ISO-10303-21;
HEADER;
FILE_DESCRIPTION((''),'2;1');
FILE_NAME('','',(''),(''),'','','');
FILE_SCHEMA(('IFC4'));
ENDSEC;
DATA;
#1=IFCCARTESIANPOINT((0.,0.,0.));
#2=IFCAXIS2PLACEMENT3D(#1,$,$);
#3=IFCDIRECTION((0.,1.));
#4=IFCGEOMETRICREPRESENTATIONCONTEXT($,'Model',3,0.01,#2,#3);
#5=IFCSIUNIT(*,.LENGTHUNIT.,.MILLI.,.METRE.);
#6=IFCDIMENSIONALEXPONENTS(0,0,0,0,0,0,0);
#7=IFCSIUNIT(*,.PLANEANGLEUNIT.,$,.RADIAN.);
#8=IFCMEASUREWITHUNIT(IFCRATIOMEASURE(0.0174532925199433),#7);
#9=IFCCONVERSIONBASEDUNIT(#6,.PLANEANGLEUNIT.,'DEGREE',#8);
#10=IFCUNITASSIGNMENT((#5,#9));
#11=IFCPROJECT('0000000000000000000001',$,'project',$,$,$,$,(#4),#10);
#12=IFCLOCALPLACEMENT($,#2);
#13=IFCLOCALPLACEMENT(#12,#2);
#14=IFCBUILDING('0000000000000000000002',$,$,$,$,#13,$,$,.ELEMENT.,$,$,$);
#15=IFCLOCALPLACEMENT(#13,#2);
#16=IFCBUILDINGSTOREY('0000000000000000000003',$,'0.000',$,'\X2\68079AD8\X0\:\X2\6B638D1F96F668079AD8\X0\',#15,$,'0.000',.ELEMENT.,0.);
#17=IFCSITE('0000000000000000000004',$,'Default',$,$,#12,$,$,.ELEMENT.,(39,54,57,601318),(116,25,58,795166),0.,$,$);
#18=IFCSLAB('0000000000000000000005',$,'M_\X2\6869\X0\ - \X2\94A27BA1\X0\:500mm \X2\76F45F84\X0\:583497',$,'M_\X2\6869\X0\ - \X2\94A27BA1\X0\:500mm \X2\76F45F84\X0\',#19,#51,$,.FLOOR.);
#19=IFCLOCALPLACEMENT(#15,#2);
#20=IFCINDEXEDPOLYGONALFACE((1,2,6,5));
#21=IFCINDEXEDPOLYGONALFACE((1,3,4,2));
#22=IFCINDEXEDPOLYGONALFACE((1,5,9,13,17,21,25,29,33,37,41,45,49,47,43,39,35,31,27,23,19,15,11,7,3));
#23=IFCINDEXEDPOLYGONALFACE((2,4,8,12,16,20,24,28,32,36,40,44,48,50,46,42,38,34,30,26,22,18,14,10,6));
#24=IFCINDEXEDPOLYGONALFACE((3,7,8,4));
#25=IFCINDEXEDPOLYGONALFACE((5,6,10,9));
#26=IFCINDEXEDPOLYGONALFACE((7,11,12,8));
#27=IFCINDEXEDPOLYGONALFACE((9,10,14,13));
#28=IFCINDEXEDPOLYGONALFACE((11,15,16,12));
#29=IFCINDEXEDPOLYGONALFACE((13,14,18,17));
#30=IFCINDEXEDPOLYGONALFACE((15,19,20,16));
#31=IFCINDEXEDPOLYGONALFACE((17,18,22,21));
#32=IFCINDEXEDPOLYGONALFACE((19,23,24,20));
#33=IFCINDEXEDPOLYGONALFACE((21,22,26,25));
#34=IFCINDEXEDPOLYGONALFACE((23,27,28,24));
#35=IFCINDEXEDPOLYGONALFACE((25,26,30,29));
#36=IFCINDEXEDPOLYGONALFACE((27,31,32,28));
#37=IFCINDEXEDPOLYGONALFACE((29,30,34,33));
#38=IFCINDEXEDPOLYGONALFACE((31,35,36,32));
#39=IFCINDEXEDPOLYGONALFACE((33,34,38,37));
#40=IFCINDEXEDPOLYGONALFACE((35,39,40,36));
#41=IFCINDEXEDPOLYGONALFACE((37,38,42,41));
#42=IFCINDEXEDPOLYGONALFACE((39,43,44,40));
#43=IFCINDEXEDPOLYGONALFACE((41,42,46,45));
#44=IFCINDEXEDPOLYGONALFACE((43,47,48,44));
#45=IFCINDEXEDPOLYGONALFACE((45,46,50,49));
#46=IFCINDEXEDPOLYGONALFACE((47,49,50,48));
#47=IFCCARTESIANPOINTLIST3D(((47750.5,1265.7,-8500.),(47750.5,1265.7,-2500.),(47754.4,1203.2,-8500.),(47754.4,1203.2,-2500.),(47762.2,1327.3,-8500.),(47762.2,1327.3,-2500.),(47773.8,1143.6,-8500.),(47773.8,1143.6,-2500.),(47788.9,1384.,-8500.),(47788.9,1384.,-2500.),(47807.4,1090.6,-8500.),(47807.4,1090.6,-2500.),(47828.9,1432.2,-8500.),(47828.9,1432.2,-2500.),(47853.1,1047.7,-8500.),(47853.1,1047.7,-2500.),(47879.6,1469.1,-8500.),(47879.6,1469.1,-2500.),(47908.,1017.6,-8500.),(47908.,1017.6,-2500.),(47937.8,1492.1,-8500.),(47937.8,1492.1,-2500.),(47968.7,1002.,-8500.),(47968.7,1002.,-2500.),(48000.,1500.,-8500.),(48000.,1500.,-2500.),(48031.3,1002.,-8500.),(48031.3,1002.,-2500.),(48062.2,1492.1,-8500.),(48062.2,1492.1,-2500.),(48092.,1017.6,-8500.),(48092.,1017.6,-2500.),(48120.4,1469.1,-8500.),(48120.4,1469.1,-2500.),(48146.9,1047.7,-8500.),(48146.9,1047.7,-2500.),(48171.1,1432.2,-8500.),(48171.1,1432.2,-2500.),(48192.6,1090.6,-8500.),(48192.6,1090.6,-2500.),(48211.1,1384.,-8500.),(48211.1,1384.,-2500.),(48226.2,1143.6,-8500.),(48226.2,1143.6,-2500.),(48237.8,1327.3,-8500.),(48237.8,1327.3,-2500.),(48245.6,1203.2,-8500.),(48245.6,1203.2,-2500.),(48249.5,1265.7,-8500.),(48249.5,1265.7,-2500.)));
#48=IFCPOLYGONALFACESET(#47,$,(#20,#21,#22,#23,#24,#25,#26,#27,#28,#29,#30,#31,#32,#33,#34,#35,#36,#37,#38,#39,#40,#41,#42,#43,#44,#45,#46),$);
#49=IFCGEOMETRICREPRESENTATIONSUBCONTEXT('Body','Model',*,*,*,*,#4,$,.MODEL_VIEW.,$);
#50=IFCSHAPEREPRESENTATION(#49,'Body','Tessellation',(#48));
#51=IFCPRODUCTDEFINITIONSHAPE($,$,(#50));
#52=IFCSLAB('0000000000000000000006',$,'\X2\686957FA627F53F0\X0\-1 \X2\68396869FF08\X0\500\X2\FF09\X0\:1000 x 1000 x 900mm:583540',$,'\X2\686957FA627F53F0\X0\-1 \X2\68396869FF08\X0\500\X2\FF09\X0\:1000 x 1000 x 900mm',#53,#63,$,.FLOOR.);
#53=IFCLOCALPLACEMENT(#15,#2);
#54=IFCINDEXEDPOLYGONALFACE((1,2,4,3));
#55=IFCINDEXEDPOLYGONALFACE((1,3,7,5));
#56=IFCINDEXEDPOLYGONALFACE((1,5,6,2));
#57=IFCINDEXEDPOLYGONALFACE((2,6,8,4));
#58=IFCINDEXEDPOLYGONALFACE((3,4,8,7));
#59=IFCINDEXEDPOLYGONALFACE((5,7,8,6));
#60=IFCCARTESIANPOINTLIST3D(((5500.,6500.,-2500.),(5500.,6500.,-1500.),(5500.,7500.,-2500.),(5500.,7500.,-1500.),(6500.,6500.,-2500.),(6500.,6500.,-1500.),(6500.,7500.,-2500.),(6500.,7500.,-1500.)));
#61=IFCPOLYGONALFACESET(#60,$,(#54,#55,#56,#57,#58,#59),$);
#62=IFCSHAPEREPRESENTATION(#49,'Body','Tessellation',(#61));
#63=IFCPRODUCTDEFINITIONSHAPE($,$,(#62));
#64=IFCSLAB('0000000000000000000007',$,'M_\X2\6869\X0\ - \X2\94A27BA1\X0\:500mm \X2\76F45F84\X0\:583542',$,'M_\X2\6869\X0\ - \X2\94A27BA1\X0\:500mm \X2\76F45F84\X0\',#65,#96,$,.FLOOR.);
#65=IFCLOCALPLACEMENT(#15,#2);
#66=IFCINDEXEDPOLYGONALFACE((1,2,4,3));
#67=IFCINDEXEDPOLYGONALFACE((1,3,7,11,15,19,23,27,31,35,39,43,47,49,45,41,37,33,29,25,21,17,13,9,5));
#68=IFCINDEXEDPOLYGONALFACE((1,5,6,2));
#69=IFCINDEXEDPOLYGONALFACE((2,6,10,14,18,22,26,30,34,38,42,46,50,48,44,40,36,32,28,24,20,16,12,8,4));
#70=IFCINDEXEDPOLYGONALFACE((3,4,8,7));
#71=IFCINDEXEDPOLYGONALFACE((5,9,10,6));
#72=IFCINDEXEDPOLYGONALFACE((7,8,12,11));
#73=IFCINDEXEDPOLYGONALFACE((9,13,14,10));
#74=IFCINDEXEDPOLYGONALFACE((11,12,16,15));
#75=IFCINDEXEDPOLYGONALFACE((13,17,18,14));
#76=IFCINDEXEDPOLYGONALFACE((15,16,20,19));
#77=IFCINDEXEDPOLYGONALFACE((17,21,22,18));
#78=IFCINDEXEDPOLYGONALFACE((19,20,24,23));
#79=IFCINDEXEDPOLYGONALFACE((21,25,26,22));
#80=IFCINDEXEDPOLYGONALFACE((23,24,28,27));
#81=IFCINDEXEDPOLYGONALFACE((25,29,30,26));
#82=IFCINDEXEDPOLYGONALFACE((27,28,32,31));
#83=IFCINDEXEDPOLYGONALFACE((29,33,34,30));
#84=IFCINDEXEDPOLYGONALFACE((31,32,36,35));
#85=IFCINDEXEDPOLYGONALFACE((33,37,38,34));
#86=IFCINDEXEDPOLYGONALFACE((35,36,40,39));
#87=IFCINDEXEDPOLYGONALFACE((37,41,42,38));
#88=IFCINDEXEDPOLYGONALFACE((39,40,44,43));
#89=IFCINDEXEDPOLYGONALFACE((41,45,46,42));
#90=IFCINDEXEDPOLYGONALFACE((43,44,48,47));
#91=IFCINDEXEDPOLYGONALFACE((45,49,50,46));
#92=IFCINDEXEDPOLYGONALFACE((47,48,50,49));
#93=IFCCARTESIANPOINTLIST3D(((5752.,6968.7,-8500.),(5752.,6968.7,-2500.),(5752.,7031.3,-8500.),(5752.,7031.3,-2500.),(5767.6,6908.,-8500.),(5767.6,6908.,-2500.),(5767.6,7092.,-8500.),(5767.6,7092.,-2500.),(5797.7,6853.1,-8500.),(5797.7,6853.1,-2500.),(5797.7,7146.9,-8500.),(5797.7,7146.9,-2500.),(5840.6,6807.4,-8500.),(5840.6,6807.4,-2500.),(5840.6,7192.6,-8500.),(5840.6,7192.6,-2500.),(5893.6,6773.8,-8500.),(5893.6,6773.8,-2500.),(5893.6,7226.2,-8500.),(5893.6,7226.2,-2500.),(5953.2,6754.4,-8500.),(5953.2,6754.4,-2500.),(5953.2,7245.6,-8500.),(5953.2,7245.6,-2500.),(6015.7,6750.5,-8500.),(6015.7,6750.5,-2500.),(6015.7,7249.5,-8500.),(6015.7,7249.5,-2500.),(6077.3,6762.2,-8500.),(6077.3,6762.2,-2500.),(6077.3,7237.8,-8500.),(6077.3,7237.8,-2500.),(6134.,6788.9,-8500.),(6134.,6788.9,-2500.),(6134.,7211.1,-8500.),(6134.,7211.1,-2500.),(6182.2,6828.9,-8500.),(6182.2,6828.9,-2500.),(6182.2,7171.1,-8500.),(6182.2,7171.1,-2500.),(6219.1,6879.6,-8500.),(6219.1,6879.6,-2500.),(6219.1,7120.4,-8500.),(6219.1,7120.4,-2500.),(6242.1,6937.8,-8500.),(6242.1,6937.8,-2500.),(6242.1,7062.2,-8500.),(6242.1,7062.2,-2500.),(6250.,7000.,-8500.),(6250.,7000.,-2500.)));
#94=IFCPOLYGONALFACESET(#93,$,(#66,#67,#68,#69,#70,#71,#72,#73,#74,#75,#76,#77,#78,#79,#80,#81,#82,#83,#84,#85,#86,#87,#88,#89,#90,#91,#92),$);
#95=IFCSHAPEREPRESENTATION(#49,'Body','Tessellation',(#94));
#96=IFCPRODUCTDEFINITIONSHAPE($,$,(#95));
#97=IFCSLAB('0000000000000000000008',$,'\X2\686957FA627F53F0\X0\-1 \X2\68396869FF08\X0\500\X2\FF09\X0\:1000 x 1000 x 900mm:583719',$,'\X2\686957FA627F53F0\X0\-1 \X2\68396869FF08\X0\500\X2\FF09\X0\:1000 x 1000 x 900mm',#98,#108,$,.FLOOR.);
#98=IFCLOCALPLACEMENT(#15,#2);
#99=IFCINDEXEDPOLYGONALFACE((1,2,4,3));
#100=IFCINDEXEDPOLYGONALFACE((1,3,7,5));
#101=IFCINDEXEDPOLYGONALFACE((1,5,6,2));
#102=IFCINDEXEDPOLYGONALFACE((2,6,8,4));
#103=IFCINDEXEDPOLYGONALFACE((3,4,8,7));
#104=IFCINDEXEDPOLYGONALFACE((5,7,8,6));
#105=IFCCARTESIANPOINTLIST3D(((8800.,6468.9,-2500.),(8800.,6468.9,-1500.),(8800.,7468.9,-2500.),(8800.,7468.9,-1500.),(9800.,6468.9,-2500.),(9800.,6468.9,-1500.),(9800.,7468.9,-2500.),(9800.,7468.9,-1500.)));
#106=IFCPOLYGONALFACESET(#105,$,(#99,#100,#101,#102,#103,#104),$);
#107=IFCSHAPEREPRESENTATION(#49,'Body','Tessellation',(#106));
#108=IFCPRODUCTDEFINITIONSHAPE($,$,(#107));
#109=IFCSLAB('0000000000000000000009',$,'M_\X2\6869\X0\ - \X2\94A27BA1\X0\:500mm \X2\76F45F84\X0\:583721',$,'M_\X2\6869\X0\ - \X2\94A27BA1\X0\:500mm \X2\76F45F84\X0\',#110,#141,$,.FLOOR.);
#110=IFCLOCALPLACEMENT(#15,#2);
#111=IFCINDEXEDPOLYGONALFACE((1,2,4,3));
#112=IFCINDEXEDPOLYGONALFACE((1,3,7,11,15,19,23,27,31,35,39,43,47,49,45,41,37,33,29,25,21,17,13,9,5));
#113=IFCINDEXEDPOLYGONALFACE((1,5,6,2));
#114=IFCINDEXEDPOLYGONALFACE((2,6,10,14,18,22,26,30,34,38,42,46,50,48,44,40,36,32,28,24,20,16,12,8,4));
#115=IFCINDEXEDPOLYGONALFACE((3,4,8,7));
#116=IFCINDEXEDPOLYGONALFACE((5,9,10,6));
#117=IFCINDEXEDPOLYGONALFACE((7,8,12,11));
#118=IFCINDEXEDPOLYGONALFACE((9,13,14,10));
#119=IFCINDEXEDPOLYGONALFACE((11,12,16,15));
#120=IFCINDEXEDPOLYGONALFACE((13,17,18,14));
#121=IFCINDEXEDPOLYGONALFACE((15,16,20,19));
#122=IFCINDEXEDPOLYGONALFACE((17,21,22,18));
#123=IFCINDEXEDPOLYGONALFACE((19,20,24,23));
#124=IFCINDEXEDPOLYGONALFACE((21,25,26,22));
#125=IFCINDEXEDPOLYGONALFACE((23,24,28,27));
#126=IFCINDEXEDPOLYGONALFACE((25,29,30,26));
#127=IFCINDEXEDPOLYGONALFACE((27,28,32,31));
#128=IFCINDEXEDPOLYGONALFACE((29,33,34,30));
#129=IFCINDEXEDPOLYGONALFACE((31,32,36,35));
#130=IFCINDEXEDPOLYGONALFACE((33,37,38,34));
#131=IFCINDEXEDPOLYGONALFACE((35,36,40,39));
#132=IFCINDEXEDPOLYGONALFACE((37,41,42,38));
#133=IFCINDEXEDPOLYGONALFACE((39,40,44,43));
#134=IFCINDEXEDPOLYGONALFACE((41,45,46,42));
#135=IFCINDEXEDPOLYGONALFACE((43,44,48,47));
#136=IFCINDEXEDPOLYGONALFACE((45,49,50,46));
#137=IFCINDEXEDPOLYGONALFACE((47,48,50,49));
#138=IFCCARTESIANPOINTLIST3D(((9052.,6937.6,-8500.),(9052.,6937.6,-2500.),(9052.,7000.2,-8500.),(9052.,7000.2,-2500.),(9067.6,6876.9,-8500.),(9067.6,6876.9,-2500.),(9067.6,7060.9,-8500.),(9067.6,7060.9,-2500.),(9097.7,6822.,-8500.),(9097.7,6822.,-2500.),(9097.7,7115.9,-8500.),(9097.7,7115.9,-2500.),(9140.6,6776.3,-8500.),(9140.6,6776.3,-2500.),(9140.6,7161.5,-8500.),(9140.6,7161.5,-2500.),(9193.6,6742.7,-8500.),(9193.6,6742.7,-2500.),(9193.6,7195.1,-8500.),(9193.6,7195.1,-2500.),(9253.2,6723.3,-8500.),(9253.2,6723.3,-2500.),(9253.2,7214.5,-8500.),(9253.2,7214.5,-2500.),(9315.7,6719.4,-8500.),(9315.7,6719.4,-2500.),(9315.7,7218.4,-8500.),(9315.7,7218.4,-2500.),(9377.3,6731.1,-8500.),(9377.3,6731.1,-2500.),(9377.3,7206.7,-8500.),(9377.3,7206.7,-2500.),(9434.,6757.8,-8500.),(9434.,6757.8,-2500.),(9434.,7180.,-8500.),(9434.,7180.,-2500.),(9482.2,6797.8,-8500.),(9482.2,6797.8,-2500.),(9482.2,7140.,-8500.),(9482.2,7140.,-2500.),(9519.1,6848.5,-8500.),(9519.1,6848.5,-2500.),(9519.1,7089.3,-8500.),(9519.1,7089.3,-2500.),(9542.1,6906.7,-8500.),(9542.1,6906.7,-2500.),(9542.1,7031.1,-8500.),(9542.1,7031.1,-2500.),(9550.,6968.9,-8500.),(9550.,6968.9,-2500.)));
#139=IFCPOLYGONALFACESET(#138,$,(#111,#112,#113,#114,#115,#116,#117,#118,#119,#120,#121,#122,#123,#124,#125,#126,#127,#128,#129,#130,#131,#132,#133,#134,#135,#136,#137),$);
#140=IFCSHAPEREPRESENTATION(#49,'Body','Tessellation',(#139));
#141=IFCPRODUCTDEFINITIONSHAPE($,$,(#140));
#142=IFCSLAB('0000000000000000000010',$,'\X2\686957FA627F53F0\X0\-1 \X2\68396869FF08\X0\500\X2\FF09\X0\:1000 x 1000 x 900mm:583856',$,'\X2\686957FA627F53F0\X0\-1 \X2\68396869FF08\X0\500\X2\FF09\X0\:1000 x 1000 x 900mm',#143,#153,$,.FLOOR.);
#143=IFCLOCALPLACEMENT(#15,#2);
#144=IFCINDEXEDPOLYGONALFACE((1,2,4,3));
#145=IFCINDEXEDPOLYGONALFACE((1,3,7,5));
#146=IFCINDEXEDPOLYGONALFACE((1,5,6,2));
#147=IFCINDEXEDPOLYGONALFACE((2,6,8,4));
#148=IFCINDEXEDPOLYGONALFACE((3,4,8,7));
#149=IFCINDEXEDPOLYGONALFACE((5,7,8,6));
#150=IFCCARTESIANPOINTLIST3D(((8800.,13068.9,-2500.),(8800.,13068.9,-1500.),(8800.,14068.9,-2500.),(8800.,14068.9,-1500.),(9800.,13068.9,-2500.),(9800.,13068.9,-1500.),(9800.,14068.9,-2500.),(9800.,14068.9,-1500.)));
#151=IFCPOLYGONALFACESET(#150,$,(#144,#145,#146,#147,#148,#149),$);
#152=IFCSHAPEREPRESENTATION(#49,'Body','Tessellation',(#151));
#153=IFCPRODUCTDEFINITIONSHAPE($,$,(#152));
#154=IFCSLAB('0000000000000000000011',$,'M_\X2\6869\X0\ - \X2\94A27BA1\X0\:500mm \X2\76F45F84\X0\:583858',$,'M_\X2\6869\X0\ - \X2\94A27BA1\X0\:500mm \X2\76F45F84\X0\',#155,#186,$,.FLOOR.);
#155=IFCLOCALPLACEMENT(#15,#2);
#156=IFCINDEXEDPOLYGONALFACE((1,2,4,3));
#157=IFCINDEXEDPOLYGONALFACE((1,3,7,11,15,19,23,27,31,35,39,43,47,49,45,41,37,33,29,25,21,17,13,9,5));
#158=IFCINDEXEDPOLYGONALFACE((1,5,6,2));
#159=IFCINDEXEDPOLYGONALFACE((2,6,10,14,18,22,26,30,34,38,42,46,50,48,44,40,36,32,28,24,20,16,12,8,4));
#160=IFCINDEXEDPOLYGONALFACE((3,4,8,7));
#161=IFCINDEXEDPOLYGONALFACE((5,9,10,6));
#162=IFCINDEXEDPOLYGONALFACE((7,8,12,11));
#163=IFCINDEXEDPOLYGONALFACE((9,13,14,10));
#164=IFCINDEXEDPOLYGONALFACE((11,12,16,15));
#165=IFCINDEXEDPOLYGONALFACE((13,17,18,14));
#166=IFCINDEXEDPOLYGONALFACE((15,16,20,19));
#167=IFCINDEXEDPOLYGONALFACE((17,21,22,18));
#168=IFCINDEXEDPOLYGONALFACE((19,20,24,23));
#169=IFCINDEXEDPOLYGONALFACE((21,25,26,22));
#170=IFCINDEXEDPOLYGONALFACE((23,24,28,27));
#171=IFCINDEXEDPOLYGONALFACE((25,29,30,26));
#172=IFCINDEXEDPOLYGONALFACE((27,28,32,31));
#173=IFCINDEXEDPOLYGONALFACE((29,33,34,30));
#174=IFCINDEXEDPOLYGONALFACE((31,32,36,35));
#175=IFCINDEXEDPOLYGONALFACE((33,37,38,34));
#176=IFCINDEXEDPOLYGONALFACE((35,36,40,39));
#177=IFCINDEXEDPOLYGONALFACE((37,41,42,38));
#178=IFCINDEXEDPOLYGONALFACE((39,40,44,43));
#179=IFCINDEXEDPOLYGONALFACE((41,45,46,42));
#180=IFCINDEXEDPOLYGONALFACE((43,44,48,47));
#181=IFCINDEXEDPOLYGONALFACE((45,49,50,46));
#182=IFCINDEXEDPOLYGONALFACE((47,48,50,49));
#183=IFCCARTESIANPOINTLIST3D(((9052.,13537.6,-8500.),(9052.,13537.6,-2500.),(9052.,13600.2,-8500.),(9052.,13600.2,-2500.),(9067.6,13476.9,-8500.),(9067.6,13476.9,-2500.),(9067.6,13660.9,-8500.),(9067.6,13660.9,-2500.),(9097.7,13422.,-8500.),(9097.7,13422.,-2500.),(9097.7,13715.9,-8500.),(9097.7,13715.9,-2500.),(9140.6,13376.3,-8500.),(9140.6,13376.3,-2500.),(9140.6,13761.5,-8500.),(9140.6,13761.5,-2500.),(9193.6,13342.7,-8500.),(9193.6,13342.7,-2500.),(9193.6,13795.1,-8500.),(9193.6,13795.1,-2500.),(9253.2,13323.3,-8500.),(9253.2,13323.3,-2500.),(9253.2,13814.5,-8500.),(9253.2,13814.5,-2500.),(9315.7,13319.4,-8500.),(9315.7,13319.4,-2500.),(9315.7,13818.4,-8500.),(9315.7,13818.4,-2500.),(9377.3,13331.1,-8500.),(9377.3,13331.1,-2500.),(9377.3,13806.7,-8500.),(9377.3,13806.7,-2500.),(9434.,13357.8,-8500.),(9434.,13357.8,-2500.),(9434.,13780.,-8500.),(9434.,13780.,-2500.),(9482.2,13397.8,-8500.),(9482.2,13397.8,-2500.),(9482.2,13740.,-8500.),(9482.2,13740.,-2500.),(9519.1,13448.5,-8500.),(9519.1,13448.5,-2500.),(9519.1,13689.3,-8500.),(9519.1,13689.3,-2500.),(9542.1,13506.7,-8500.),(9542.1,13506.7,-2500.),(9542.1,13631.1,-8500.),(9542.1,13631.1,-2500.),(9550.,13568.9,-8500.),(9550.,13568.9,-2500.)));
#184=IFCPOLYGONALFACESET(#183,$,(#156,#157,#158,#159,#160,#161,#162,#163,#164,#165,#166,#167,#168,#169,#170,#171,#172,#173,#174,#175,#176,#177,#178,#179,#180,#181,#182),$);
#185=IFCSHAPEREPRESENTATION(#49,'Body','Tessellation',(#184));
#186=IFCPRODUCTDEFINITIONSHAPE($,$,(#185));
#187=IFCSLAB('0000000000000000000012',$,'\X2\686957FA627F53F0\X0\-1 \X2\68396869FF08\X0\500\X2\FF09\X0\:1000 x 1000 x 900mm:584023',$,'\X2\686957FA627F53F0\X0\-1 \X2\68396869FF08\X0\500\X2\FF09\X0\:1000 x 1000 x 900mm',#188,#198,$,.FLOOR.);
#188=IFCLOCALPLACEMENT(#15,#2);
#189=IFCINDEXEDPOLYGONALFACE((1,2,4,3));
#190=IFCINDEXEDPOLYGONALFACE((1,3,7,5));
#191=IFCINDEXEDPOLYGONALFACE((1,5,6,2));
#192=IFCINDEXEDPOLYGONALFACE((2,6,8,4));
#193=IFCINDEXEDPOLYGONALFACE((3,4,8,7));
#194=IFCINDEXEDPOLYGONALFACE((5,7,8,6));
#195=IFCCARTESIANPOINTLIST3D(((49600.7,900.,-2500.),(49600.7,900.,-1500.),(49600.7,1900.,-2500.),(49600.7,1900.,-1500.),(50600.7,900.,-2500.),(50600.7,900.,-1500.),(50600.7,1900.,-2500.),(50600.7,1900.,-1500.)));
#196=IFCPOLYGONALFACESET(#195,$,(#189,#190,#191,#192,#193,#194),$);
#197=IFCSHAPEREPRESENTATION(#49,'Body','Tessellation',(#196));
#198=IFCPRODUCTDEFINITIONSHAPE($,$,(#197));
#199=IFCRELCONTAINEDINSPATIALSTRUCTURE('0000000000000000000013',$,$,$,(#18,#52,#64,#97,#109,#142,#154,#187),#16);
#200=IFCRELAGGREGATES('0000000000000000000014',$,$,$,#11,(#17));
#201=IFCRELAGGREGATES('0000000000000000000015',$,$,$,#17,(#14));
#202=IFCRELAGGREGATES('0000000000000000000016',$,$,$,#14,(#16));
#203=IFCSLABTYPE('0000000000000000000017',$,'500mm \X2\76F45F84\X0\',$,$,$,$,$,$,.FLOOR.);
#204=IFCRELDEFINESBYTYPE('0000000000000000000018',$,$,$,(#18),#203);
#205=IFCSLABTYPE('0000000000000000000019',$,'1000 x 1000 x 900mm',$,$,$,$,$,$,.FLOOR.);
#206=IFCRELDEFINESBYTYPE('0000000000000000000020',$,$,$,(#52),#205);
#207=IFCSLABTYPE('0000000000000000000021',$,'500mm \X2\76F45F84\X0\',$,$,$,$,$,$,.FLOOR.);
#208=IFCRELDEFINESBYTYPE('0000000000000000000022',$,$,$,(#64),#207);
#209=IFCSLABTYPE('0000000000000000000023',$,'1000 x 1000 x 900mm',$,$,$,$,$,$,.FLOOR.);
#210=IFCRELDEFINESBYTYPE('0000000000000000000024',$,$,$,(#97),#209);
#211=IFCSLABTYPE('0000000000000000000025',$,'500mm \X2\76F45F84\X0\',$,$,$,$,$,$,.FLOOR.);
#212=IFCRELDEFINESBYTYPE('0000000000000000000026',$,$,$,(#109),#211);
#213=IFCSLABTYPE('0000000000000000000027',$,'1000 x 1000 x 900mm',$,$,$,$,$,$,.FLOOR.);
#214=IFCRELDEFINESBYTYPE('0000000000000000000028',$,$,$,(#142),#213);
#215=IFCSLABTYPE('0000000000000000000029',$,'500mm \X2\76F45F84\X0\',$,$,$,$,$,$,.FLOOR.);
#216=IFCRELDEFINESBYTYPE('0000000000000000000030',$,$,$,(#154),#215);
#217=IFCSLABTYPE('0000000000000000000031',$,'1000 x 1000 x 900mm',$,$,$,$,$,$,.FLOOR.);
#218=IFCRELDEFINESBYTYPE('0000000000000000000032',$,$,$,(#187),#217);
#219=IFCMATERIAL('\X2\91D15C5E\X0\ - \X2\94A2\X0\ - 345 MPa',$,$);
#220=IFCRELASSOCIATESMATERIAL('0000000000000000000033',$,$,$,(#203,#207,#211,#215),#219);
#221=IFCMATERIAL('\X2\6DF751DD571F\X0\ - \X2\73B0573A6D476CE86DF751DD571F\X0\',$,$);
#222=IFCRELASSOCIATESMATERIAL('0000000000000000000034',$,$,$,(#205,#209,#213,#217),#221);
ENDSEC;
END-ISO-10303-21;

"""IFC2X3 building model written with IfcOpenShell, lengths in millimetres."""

from ifc_helpers import new_model, entity, si_unit, converted_unit, direction, frame, frame_2d, origin, origin_2d_with_axis, place, context, subcontext, project, spatial, rectangle, circle, extrude, material, type_object, element, save


model = new_model("IFC2X3")

# Units and contexts
model_context = context("Model", 3, precision=0.01, world=origin(), true_north=direction((0.0, 1.0)))
body_context = subcontext(model_context, "Body", "Model", "MODEL_VIEW")
ifc_project = project(units=[si_unit("LENGTHUNIT", "METRE", prefix="MILLI"), converted_unit("PLANEANGLEUNIT", "DEGREE", entity("IfcRatioMeasure", 0.0174532925199433), si_unit("PLANEANGLEUNIT", "RADIAN"), dimensions=[0, 0, 0, 0, 0, 0, 0])], contexts=[model_context])

# Site, building, storey
site_placement = place(None, origin())
site = spatial("IfcSite", under=ifc_project, at=site_placement, Name="Default", CompositionType="ELEMENT", RefLatitude=(39, 54, 57, 601318), RefLongitude=(116, 25, 58, 795166), RefElevation=0.0)
building_placement = place(site_placement, origin())
building = spatial("IfcBuilding", under=site, at=building_placement, CompositionType="ELEMENT")
storey_placement = place(building_placement, origin())
storey = spatial("IfcBuildingStorey", under=building, at=storey_placement, Name="0.000", ObjectType="标高:正负零标高", LongName="0.000", CompositionType="ELEMENT", Elevation=0.0)

# Slabs
ifc_material_1 = material(Name="金属 - 钢 - 345 MPa")
ifc_material_2 = material(Name="混凝土 - 现场浇注混凝土")
slab_type_1 = type_object("IfcSlabType", Name="500mm 直径", PredefinedType="FLOOR", material=ifc_material_1)
slab_1_placement = place(storey_placement, origin())
element("IfcSlab", 1, at=slab_1_placement, inside=storey, type_object=slab_type_1, Name="M_桩 - 钢管:500mm 直径:583497", ObjectType="M_桩 - 钢管:500mm 直径", PredefinedType="FLOOR", context=body_context, shape_type="SweptSolid", body=[
    extrude(circle(Radius=250.0, at=origin_2d_with_axis()), frame((48000.0, 1250.0, -8500.0), z_axis=(0.0, 0.0, 1.0), x_axis=(0.0, 1.0, 0.0)), (0.0, 0.0, 1.0), 6000.0),
])
slab_type_2 = type_object("IfcSlabType", Name="1000 x 1000 x 900mm", PredefinedType="FLOOR", material=ifc_material_2)
slab_2_placement = place(storey_placement, origin())
element("IfcSlab", 2, at=slab_2_placement, inside=storey, type_object=slab_type_2, Name="桩基承台-1 根桩（500）:1000 x 1000 x 900mm:583540", ObjectType="桩基承台-1 根桩（500）:1000 x 1000 x 900mm", PredefinedType="FLOOR", context=body_context, shape_type="SweptSolid", body=[
    extrude(rectangle(XDim=1000.0, YDim=1000.0, at=origin_2d_with_axis()), frame((6000.0, 7000.0, -2500.0), z_axis=(0.0, 0.0, 1.0), x_axis=(-1.0, 0.0, 0.0)), (0.0, 0.0, 1.0), 1000.0),
])
slab_type_3 = type_object("IfcSlabType", Name="500mm 直径", PredefinedType="FLOOR", material=ifc_material_1)
slab_3_placement = place(storey_placement, origin())
element("IfcSlab", 3, at=slab_3_placement, inside=storey, type_object=slab_type_3, Name="M_桩 - 钢管:500mm 直径:583542", ObjectType="M_桩 - 钢管:500mm 直径", PredefinedType="FLOOR", context=body_context, shape_type="SweptSolid", body=[
    extrude(circle(Radius=250.0, at=origin_2d_with_axis()), frame((6000.0, 7000.0, -8500.0)), (0.0, 0.0, 1.0), 6000.0),
])
slab_type_4 = type_object("IfcSlabType", Name="1000 x 1000 x 900mm", PredefinedType="FLOOR", material=ifc_material_2)
slab_4_placement = place(storey_placement, origin())
element("IfcSlab", 4, at=slab_4_placement, inside=storey, type_object=slab_type_4, Name="桩基承台-1 根桩（500）:1000 x 1000 x 900mm:583719", ObjectType="桩基承台-1 根桩（500）:1000 x 1000 x 900mm", PredefinedType="FLOOR", context=body_context, shape_type="SweptSolid", body=[
    extrude(rectangle(XDim=1000.0, YDim=1000.0, at=frame_2d((0.0, 0.0), x_axis=(1.0, 0.0))), frame((9300.0, 6968.9, -2500.0), z_axis=(0.0, 0.0, 1.0), x_axis=(-1.0, 0.0, 0.0)), (0.0, 0.0, 1.0), 1000.0),
])
slab_type_5 = type_object("IfcSlabType", Name="500mm 直径", PredefinedType="FLOOR", material=ifc_material_1)
slab_5_placement = place(storey_placement, origin())
element("IfcSlab", 5, at=slab_5_placement, inside=storey, type_object=slab_type_5, Name="M_桩 - 钢管:500mm 直径:583721", ObjectType="M_桩 - 钢管:500mm 直径", PredefinedType="FLOOR", context=body_context, shape_type="SweptSolid", body=[
    extrude(circle(Radius=250.0, at=origin_2d_with_axis()), frame((9300.0, 6968.9, -8500.0)), (0.0, 0.0, 1.0), 6000.0),
])
slab_type_6 = type_object("IfcSlabType", Name="1000 x 1000 x 900mm", PredefinedType="FLOOR", material=ifc_material_2)
slab_6_placement = place(storey_placement, origin())
element("IfcSlab", 6, at=slab_6_placement, inside=storey, type_object=slab_type_6, Name="桩基承台-1 根桩（500）:1000 x 1000 x 900mm:583856", ObjectType="桩基承台-1 根桩（500）:1000 x 1000 x 900mm", PredefinedType="FLOOR", context=body_context, shape_type="SweptSolid", body=[
    extrude(rectangle(XDim=1000.0, YDim=1000.0, at=frame_2d((0.0, 0.0), x_axis=(1.0, 0.0))), frame((9300.0, 13568.9, -2500.0), z_axis=(0.0, 0.0, 1.0), x_axis=(-1.0, 0.0, 0.0)), (0.0, 0.0, 1.0), 1000.0),
])
slab_type_7 = type_object("IfcSlabType", Name="500mm 直径", PredefinedType="FLOOR", material=ifc_material_1)
slab_7_placement = place(storey_placement, origin())
element("IfcSlab", 7, at=slab_7_placement, inside=storey, type_object=slab_type_7, Name="M_桩 - 钢管:500mm 直径:583858", ObjectType="M_桩 - 钢管:500mm 直径", PredefinedType="FLOOR", context=body_context, shape_type="SweptSolid", body=[
    extrude(circle(Radius=250.0, at=origin_2d_with_axis()), frame((9300.0, 13568.9, -8500.0)), (0.0, 0.0, 1.0), 6000.0),
])
slab_type_8 = type_object("IfcSlabType", Name="1000 x 1000 x 900mm", PredefinedType="FLOOR", material=ifc_material_2)
slab_8_placement = place(storey_placement, origin())
element("IfcSlab", 8, at=slab_8_placement, inside=storey, type_object=slab_type_8, Name="桩基承台-1 根桩（500）:1000 x 1000 x 900mm:584023", ObjectType="桩基承台-1 根桩（500）:1000 x 1000 x 900mm", PredefinedType="FLOOR", context=body_context, shape_type="SweptSolid", body=[
    extrude(rectangle(XDim=1000.0, YDim=1000.0, at=frame_2d((0.0, 0.0), x_axis=(1.0, 0.0))), frame((50100.7, 1400.0, -2500.0), z_axis=(0.0, 0.0, 1.0), x_axis=(-1.0, 0.0, 0.0)), (0.0, 0.0, 1.0), 1000.0),
])

save(model, "model.ifc")
